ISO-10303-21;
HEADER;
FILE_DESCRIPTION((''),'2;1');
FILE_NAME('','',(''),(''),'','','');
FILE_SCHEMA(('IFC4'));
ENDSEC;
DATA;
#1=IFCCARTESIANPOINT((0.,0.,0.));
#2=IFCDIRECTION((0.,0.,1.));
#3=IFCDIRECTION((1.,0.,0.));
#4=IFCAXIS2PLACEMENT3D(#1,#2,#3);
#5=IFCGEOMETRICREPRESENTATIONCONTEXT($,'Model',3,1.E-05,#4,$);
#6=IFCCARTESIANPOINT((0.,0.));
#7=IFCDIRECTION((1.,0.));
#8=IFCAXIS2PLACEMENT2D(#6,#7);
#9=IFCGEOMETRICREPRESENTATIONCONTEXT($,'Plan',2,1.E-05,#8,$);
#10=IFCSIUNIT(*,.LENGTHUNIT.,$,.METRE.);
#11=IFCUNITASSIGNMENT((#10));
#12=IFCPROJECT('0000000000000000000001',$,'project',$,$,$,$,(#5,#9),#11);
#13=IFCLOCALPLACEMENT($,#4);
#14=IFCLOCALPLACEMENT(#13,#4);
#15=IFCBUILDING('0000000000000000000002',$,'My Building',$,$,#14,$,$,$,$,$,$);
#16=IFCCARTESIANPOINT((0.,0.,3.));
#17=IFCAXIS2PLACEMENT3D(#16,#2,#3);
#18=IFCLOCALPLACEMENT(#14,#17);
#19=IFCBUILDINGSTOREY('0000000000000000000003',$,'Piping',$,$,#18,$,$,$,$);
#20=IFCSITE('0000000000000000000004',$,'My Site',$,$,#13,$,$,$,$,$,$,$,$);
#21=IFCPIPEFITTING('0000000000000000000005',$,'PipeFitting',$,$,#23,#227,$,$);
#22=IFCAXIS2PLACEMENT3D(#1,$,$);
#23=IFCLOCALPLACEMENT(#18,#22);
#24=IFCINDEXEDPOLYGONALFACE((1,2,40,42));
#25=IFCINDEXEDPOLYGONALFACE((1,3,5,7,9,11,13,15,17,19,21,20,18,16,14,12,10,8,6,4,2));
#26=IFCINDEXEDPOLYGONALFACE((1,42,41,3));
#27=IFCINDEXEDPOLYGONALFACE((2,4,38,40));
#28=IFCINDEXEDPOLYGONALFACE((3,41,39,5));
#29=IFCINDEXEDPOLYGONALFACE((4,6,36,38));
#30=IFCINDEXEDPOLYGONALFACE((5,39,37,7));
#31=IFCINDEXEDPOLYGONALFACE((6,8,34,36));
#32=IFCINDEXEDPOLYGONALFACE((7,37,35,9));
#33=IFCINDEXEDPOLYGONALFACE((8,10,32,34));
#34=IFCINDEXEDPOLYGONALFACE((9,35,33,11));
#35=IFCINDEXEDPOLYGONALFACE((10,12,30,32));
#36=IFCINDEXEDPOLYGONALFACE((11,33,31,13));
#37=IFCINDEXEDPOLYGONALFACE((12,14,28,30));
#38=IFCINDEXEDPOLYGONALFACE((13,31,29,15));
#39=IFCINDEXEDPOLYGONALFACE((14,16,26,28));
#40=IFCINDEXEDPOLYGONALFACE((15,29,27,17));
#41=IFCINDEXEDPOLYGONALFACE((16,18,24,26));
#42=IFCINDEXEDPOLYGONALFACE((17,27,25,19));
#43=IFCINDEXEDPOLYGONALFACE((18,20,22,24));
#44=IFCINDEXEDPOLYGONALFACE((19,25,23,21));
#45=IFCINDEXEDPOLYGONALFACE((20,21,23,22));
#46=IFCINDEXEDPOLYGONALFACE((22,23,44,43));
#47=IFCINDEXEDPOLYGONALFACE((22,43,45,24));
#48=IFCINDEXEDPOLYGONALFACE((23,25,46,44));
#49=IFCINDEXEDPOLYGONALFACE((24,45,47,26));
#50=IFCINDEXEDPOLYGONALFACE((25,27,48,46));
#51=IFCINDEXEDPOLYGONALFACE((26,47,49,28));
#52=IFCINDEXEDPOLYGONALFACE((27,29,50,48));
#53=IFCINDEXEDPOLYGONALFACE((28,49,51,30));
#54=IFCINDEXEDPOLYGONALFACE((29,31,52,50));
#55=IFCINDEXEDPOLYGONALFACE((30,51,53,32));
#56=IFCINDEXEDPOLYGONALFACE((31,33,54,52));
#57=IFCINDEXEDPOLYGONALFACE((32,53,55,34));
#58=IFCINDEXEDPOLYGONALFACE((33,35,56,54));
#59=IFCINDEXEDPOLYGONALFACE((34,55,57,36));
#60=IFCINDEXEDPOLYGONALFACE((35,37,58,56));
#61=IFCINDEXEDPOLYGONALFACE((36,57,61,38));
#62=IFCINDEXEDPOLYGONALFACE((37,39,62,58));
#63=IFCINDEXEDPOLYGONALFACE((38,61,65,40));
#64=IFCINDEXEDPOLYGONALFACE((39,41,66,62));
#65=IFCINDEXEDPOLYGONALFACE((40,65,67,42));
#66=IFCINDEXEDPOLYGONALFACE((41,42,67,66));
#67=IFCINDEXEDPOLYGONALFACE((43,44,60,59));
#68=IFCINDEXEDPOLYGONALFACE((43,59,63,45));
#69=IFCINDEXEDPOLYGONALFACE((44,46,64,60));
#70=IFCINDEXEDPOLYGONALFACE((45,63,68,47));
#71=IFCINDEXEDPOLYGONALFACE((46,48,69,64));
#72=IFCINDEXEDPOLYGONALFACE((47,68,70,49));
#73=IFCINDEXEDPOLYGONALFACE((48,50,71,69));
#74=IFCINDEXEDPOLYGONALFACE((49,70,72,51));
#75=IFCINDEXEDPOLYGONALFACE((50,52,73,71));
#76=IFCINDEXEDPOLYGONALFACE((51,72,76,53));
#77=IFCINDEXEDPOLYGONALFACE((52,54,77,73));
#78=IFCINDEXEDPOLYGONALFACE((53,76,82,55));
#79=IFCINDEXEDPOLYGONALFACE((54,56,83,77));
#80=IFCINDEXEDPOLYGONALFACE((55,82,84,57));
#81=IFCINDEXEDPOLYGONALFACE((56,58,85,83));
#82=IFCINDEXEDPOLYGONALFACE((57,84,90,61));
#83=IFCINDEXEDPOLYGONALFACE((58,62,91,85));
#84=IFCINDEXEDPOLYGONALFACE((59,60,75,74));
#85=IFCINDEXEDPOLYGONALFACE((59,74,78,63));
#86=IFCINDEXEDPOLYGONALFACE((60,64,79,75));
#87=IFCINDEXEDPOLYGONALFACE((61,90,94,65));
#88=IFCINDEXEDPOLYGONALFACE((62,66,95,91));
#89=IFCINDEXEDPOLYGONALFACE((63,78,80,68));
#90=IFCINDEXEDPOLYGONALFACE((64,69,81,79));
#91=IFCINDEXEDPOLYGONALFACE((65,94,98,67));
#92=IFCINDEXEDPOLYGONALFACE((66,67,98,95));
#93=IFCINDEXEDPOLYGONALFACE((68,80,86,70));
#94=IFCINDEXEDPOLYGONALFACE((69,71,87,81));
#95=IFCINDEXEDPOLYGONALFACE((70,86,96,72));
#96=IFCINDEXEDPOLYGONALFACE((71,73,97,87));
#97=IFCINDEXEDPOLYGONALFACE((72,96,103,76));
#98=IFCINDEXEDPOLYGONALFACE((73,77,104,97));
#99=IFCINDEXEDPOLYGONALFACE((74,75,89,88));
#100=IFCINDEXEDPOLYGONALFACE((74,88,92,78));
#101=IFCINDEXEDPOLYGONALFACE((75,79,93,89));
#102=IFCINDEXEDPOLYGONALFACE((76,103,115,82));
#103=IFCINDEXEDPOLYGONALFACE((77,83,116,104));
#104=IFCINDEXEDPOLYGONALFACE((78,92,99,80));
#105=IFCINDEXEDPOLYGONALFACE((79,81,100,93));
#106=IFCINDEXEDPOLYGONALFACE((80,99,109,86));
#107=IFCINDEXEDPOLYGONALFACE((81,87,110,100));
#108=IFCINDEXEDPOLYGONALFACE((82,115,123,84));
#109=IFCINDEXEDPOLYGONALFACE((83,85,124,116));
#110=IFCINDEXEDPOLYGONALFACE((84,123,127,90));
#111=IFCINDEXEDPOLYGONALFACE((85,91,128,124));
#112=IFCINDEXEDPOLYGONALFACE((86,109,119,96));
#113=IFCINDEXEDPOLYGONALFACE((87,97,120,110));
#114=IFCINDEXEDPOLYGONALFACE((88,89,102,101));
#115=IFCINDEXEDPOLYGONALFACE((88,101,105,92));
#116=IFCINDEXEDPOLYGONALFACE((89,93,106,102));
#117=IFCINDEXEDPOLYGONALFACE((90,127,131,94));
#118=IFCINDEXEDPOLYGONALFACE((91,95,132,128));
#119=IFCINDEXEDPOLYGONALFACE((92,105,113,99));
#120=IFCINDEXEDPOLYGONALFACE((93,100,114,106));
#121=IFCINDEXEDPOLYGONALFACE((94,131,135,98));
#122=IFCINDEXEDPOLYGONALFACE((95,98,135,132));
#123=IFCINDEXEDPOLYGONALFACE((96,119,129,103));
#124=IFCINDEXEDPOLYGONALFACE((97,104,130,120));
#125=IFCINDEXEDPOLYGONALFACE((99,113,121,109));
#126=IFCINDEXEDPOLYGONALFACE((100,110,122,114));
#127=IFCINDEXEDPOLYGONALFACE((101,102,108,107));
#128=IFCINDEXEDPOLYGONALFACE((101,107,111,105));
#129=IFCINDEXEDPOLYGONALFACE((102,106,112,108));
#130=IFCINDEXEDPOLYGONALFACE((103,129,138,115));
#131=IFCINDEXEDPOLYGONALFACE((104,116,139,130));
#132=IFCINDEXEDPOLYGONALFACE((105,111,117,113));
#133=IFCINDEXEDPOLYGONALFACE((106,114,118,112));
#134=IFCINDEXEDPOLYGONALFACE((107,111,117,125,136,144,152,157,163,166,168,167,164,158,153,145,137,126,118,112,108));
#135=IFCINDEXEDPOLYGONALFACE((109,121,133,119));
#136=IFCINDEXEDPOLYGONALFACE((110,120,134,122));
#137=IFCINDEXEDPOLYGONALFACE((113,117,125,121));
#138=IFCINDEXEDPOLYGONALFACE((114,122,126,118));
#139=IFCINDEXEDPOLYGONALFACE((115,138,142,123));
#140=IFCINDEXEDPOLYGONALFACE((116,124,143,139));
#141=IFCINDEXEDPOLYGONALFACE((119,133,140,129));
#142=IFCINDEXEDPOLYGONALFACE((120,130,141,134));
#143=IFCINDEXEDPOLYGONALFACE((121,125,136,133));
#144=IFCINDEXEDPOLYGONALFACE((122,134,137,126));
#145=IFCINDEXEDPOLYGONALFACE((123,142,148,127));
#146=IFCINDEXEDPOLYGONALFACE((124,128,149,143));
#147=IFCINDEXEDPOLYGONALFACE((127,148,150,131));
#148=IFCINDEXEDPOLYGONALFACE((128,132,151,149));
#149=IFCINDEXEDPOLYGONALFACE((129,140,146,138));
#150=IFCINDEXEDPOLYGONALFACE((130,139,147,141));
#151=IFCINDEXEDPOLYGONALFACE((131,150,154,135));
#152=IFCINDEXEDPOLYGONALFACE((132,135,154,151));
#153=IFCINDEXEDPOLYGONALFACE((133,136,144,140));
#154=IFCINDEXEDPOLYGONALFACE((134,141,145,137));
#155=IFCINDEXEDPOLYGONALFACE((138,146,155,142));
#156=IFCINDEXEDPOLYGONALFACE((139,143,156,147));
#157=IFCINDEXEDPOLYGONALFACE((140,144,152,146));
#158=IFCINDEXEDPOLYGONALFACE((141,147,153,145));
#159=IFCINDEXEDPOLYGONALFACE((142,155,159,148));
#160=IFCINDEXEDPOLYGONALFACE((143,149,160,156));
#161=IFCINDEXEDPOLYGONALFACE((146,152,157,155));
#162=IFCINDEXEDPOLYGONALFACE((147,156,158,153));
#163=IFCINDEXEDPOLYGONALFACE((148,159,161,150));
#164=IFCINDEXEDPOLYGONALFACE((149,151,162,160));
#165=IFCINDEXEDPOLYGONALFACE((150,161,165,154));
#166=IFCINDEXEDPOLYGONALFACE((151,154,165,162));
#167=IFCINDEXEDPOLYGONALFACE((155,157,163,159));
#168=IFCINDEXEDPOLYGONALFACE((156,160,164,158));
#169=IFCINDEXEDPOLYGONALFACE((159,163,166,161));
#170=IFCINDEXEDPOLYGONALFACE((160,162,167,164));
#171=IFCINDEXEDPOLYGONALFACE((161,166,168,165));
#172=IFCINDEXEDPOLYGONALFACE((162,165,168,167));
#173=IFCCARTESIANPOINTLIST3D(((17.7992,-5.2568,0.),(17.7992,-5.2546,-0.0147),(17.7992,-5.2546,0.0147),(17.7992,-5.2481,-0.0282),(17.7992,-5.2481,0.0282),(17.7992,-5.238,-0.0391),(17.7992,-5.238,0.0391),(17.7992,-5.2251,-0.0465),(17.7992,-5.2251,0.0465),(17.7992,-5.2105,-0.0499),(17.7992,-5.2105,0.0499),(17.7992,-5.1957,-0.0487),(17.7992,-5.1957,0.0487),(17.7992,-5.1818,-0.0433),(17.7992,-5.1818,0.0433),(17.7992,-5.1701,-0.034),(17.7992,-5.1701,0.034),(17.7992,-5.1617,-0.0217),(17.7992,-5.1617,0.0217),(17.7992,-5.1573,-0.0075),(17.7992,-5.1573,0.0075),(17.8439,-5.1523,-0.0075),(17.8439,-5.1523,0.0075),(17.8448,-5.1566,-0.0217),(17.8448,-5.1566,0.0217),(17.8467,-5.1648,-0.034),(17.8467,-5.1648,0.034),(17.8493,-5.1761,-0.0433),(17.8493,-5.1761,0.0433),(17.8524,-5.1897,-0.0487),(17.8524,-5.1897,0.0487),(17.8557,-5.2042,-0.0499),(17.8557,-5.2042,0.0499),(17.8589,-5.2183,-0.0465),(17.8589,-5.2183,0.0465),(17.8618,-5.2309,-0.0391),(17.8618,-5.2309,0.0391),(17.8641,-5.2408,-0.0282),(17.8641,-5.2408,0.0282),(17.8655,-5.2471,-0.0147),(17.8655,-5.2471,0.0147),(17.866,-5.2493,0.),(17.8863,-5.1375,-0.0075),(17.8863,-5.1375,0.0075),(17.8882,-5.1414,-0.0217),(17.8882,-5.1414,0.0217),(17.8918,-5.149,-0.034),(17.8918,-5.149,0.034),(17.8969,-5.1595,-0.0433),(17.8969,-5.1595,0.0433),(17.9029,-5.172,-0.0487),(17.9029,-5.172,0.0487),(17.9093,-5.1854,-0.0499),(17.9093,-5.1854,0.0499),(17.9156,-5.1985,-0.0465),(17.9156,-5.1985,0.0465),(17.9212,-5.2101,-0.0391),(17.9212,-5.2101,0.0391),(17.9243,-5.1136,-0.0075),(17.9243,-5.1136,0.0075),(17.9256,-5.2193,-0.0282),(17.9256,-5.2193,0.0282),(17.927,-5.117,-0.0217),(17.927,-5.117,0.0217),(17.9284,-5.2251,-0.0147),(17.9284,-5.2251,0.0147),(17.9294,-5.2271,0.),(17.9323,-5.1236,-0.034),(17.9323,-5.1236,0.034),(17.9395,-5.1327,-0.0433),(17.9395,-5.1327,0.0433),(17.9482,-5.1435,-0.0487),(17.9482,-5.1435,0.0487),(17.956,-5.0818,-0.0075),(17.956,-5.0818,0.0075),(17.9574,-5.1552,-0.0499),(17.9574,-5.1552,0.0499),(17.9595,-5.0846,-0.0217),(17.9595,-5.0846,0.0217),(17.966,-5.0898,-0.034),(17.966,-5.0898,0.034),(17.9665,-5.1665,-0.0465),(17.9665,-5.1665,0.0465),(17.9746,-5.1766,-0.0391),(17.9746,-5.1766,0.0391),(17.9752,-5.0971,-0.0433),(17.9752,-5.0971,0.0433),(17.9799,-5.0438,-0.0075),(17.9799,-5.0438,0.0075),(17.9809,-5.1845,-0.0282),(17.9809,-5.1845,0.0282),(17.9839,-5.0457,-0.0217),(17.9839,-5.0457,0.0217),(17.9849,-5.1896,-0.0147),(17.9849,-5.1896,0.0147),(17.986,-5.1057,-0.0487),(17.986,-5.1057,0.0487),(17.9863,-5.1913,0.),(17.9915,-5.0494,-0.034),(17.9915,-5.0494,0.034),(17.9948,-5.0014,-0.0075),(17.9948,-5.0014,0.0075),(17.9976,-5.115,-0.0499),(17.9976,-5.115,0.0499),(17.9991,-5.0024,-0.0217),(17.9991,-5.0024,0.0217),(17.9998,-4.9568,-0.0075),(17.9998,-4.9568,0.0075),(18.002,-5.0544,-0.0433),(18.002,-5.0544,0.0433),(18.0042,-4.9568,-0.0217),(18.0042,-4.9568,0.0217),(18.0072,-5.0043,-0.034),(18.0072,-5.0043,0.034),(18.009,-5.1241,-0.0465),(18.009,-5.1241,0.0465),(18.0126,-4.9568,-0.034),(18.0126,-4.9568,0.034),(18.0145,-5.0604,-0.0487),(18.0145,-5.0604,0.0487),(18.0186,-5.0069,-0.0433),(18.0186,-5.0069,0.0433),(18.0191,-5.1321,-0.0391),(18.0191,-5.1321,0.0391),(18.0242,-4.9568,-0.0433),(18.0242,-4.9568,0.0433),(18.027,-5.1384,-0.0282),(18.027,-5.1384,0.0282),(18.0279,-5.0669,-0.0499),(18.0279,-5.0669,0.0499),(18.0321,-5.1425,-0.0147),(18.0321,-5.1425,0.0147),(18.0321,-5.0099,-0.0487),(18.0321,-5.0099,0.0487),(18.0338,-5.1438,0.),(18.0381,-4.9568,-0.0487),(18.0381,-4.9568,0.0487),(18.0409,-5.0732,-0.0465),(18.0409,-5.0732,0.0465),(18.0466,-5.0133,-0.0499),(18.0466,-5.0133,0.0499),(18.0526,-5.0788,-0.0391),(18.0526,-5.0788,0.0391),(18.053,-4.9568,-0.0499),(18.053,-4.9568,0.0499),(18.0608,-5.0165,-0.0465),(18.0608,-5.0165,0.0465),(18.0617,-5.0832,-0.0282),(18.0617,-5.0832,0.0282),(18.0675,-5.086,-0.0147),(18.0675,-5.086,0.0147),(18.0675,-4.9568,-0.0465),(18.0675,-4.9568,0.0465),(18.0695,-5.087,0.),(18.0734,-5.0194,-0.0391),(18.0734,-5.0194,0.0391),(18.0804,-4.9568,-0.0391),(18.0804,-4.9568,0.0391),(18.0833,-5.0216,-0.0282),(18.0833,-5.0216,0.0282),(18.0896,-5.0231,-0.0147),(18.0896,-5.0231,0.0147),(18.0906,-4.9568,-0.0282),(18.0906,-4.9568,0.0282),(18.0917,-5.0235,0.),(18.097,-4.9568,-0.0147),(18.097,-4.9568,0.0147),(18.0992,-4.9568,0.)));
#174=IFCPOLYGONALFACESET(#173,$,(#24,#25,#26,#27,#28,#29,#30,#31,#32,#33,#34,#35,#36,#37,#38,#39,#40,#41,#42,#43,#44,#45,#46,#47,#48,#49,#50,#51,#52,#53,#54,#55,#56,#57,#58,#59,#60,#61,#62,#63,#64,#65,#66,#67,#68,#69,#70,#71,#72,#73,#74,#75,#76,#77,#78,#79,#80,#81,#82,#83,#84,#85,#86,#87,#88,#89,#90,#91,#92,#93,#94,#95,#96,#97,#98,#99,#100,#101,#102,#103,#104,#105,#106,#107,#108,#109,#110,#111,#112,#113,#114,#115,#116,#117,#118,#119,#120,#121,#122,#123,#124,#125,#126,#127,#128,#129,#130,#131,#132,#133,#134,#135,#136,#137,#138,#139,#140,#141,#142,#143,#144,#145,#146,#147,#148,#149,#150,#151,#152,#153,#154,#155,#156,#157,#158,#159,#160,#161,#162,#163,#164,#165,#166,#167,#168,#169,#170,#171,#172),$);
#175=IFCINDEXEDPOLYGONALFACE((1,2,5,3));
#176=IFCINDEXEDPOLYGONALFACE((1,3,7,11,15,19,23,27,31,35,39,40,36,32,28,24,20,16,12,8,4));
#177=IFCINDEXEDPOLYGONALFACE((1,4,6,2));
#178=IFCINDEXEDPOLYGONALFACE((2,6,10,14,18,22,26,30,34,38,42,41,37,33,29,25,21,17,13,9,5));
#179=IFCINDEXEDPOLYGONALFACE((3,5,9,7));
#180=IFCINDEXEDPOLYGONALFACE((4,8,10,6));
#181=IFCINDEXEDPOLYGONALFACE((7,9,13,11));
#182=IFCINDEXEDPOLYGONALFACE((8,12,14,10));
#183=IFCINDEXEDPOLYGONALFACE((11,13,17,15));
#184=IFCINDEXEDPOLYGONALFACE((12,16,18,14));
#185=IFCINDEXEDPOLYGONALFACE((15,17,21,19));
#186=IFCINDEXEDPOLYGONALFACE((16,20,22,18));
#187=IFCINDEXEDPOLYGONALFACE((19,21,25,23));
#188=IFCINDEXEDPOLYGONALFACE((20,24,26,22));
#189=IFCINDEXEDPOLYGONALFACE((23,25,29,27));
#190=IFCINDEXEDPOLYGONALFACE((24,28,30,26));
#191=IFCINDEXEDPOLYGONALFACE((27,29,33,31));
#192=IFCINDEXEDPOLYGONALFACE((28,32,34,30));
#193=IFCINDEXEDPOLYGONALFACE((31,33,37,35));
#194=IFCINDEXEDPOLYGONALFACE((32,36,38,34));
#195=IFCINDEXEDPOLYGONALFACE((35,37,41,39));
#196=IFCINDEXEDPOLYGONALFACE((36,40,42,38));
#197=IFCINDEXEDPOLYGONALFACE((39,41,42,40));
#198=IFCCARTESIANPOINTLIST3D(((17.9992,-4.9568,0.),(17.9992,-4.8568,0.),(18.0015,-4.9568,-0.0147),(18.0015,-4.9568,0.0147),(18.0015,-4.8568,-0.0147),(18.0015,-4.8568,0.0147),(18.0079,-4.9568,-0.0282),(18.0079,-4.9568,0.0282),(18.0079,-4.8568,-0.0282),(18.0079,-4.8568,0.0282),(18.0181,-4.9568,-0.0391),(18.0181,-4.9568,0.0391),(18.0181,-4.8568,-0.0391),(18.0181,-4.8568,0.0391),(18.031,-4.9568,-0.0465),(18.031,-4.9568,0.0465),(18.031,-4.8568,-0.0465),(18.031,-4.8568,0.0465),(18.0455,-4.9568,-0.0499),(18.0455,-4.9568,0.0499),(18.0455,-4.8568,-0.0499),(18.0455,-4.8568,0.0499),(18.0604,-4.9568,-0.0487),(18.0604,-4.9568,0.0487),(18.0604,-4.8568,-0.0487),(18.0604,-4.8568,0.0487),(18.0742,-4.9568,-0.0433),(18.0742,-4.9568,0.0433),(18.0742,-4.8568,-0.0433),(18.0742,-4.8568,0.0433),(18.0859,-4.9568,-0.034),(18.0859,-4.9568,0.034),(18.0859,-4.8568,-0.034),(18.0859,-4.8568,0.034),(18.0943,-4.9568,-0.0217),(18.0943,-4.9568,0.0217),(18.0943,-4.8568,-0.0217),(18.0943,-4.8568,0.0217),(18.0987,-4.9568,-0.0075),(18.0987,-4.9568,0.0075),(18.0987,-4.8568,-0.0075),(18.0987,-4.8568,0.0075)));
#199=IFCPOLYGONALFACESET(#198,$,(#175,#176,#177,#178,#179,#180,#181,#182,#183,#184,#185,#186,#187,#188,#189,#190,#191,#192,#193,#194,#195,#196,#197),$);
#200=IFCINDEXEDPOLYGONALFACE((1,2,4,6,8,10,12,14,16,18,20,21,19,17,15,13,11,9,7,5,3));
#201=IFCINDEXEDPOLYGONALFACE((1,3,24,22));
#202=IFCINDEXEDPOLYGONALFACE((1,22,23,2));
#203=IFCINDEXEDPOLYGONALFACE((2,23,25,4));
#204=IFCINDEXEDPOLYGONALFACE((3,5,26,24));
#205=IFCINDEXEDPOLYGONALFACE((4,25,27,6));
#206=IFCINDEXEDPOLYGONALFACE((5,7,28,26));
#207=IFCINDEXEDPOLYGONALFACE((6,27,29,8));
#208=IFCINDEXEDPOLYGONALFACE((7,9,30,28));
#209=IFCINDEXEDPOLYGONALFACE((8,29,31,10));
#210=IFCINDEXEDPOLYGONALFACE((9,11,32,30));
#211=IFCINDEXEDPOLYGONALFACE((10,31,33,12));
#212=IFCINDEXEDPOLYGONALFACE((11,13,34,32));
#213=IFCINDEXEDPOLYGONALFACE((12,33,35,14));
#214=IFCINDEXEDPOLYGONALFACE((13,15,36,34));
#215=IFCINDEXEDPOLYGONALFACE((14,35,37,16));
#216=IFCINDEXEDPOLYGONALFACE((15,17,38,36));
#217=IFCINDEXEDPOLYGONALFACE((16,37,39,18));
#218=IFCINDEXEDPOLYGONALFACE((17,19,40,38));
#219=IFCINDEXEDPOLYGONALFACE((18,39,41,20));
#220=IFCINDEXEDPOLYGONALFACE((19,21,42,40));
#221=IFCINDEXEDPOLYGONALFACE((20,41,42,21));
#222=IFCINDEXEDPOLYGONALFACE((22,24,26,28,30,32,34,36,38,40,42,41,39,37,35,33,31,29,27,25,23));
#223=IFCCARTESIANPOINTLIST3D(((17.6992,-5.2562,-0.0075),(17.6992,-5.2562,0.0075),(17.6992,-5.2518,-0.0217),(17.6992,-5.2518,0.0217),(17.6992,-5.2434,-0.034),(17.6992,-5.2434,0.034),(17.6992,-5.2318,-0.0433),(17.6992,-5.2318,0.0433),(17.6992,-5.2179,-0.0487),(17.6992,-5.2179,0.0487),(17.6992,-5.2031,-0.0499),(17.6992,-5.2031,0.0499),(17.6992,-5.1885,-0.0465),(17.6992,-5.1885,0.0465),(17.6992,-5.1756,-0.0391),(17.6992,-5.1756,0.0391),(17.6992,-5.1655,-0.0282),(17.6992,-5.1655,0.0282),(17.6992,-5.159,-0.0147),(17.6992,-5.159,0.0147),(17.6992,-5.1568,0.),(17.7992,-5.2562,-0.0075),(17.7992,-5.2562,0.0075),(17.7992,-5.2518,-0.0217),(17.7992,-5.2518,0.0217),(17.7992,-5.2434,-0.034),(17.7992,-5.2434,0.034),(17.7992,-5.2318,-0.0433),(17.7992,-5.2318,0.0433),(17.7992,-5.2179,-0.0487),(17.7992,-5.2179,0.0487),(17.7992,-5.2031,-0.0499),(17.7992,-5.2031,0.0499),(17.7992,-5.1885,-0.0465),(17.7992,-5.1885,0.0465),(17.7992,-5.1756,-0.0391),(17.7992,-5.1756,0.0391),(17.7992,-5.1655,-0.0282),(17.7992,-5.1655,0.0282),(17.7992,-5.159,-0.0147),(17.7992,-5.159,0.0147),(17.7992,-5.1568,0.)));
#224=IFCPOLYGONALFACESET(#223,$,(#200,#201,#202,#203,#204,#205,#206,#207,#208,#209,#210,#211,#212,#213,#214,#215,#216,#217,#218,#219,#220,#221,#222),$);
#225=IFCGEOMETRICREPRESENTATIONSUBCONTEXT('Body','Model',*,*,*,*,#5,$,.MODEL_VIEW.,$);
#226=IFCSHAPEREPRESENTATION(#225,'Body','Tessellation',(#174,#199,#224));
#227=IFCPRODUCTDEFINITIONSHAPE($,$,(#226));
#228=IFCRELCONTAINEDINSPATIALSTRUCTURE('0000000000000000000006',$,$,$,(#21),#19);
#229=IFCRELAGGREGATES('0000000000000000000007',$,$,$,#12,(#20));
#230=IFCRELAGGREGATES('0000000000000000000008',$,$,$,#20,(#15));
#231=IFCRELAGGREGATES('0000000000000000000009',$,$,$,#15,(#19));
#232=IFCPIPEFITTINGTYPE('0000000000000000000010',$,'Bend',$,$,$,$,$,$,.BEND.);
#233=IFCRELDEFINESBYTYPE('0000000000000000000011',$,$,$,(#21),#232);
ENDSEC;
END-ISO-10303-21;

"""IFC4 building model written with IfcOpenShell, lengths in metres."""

from ifc_helpers import new_model, entity, si_unit, frame, origin_with_axes, origin_2d_with_axis, place, context, subcontext, project, spatial, circle, extrude, source, transform, mapped, type_object, type_shapes, element, save


model = new_model("IFC4")

# Units and contexts
model_context = context("Model", 3, precision=1e-05, world=origin_with_axes())
plan_context = context("Plan", 2, precision=1e-05, world=origin_2d_with_axis())
body_context = subcontext(model_context, "Body", "Model", "MODEL_VIEW")
ifc_project = project(units=[si_unit("LENGTHUNIT", "METRE")], contexts=[model_context, plan_context])

# Site, building, storey
site_placement = place(None, origin_with_axes())
site = spatial("IfcSite", under=ifc_project, at=site_placement, Name="My Site")
building_placement = place(site_placement, origin_with_axes())
building = spatial("IfcBuilding", under=site, at=building_placement, Name="My Building")
storey_placement = place(building_placement, frame((0.0, 0.0, 3.0), z_axis=(0.0, 0.0, 1.0), x_axis=(1.0, 0.0, 0.0)))
storey = spatial("IfcBuildingStorey", under=building, at=storey_placement, Name="Piping")

# Pipe fitting
pipe_fitting_type_1 = type_object("IfcPipeFittingType", Name="Bend", PredefinedType="BEND")
shared_shape_1 = source(origin_with_axes(), body_context, "Body", "SolidModel", [
    entity("IfcSweptDiskSolid", entity("IfcIndexedPolyCurve", entity("IfcCartesianPointList3D", [[0.0, 0.0, -0.1], [0.0732, 0.0, -0.2768], [0.25, 0.0, -0.35]]), [entity("IfcArcIndex", [1, 2, 3])]), 0.05),
    extrude(circle(Radius=0.05), origin_with_axes(), (0.0, 0.0, -1.0), 0.1),
    extrude(circle(Radius=0.05), frame((0.25, 0.0, -0.35), z_axis=(1.0, 0.0, 0.0), x_axis=(0.0, 0.0, 1.0)), (0.0, 0.0, 1.0), 0.1),
])
type_shapes(pipe_fitting_type_1, [shared_shape_1])
for number, where, z_axis, x_axis, name in (
    (1, (18.0492, -4.8568, 0.0), (0.0, 1.0, 0.0), (-1.0, 0.0, 0.0), "PipeFitting"),
):
    element("IfcPipeFitting", number, at=place(storey_placement, frame(where, z_axis=z_axis, x_axis=x_axis)), inside=storey, type_object=pipe_fitting_type_1, Name=name, context=body_context, shape_type="MappedRepresentation", body=[
        mapped(shared_shape_1, transform((0.0, 0.0, 0.0), x_axis=(1.0, 0.0, 0.0), y_axis=(0.0, 1.0, 0.0), z_axis=(0.0, 0.0, 1.0), scale=1.0)),
    ])

save(model, "model.ifc")
